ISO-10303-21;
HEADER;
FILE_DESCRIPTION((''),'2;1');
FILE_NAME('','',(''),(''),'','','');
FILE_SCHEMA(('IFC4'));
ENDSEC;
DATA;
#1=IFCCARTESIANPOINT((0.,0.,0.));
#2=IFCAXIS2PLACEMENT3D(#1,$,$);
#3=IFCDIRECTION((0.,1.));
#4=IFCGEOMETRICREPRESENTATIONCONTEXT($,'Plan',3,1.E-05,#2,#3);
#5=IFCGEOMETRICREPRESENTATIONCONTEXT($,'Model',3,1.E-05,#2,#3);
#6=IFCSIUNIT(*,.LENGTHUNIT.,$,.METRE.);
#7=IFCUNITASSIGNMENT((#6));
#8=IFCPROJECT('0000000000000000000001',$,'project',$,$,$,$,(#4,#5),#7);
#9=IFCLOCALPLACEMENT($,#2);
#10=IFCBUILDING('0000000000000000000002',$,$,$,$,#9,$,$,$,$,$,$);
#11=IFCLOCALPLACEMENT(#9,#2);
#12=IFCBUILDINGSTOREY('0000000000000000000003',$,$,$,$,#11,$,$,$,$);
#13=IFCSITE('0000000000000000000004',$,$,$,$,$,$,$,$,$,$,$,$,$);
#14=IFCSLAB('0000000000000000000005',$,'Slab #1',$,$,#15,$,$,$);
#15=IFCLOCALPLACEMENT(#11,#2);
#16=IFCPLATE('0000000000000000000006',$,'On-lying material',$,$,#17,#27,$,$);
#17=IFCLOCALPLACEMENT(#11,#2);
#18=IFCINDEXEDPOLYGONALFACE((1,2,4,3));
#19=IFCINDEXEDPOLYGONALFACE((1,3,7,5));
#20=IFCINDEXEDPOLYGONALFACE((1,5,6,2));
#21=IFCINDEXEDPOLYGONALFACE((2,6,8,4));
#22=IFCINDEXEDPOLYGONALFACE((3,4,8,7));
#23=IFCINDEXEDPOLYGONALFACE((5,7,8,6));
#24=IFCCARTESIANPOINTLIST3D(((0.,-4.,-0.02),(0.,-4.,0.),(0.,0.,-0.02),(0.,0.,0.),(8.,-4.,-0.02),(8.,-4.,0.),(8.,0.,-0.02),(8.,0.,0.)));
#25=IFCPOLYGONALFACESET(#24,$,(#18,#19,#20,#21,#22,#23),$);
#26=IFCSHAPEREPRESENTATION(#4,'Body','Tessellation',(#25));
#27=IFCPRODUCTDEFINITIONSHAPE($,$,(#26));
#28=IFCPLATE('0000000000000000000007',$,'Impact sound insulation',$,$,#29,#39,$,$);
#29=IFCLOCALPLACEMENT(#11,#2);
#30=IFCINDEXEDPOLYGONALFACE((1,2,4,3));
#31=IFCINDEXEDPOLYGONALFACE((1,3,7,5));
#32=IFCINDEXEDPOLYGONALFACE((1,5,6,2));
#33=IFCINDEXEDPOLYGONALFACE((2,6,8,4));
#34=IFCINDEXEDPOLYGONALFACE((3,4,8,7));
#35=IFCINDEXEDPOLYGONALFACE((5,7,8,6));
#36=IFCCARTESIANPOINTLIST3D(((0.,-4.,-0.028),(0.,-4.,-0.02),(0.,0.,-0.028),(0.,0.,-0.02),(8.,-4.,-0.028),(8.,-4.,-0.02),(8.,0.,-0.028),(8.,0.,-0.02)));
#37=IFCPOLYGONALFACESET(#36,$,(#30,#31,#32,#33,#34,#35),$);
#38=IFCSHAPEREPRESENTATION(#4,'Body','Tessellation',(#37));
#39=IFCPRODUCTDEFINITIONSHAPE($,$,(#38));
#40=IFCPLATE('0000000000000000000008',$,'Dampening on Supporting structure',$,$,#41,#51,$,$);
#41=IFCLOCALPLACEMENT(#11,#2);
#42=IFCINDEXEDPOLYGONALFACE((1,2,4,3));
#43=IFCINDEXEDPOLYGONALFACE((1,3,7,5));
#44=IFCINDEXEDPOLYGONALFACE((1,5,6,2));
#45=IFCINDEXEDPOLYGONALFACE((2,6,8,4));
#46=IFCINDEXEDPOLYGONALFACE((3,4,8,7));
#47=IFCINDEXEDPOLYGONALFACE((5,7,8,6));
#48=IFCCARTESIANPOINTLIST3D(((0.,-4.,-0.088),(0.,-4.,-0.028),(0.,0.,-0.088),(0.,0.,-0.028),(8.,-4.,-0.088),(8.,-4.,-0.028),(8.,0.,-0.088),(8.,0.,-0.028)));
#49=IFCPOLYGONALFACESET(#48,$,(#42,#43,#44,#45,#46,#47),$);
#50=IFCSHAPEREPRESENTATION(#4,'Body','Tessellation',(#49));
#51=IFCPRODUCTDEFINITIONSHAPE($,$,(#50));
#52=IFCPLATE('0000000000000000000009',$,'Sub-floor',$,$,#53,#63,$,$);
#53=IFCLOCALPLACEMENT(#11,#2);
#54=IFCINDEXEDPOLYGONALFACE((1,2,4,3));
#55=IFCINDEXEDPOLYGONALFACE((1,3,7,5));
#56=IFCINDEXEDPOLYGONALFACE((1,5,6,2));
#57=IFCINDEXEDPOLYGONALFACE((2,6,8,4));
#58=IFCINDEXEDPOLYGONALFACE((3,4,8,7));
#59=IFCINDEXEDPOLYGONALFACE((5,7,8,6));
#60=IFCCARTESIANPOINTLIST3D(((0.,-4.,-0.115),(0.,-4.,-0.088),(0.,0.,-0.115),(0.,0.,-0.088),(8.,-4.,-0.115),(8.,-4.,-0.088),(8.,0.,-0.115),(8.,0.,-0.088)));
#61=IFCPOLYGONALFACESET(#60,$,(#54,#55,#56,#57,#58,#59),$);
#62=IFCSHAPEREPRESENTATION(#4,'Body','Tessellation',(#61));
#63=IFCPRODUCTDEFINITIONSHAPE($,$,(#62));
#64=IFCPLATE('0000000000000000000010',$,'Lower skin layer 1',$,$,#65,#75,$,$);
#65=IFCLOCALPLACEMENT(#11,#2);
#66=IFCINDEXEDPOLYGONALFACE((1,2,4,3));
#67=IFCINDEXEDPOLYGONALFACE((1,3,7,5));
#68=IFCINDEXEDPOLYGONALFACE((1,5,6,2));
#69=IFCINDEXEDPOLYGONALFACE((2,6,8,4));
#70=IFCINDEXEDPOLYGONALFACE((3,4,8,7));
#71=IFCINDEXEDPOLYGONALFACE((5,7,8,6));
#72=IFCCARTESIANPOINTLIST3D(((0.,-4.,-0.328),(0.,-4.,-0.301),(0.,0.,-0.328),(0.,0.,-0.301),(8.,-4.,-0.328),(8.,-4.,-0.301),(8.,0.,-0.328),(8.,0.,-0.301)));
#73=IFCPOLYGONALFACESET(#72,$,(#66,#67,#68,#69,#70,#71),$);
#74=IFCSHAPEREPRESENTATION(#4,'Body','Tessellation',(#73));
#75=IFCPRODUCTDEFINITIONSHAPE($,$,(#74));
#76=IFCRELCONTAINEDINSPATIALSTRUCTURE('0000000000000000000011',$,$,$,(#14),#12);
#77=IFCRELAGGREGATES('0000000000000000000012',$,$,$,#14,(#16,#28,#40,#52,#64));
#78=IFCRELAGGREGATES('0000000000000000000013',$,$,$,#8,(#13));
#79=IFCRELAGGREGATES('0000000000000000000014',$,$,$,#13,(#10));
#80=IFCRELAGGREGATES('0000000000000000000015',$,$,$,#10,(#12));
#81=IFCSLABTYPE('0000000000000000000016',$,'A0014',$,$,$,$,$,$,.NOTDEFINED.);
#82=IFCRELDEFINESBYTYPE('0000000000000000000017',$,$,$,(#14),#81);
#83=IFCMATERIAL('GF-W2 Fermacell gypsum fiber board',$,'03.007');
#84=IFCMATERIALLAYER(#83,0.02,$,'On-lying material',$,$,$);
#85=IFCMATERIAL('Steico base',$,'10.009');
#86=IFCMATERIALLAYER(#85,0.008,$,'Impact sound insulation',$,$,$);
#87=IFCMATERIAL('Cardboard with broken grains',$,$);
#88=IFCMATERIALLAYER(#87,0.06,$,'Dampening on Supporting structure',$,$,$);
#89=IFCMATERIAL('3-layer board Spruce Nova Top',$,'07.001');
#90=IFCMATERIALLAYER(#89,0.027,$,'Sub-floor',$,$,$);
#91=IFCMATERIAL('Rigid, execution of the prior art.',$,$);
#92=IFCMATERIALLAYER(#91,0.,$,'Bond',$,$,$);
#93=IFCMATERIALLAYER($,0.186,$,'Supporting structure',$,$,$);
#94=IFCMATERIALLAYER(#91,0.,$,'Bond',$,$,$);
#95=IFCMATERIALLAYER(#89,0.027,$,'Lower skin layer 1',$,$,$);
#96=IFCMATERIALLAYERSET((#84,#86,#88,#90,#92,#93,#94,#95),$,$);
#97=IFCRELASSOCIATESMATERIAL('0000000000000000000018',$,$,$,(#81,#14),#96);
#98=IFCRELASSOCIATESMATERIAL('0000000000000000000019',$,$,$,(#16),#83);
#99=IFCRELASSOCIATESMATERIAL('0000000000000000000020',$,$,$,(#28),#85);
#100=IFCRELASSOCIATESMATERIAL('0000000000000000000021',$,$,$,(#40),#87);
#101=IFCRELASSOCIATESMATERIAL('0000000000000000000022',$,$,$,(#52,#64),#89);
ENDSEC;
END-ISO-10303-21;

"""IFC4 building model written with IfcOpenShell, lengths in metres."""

from ifc_helpers import new_model, si_unit, direction, frame, frame_2d, origin, origin_with_axes, place, context, project, spatial, rectangle, extrude, material, layer, layer_set, type_object, element, aggregate, save


model = new_model("IFC4")

# Units and contexts
plan_context = context("Plan", 3, precision=1e-05, world=origin(), true_north=direction((0.0, 1.0)))
model_context = context("Model", 3, precision=1e-05, world=origin(), true_north=direction((0.0, 1.0)))
ifc_project = project(units=[si_unit("LENGTHUNIT", "METRE")], contexts=[plan_context, model_context])

# Site, building, storey
site = spatial("IfcSite", under=ifc_project)
building_placement = place(None, origin())
building = spatial("IfcBuilding", under=site, at=building_placement)
storey_placement = place(building_placement, origin())
storey = spatial("IfcBuildingStorey", under=building, at=storey_placement)

# Slab, plates
ifc_material_1 = material(Name="GF-W2 Fermacell gypsum fiber board", Category="03.007")
ifc_layer_1 = layer(ifc_material_1, 0.02, Name="On-lying material")
ifc_material_2 = material(Name="Steico base", Category="10.009")
ifc_layer_2 = layer(ifc_material_2, 0.008, Name="Impact sound insulation")
ifc_material_3 = material(Name="Cardboard with broken grains")
ifc_layer_3 = layer(ifc_material_3, 0.06, Name="Dampening on Supporting structure")
ifc_material_4 = material(Name="3-layer board Spruce Nova Top", Category="07.001")
ifc_layer_4 = layer(ifc_material_4, 0.027, Name="Sub-floor")
ifc_material_5 = material(Name="Rigid, execution of the prior art.")
ifc_layer_5 = layer(ifc_material_5, 0.0, Name="Bond")
ifc_layer_6 = layer(None, 0.186, Name="Supporting structure")
ifc_layer_7 = layer(ifc_material_5, 0.0, Name="Bond")
ifc_layer_8 = layer(ifc_material_4, 0.027, Name="Lower skin layer 1")
ifc_layer_set = layer_set([ifc_layer_1, ifc_layer_2, ifc_layer_3, ifc_layer_4, ifc_layer_5, ifc_layer_6, ifc_layer_7, ifc_layer_8])
slab_type = type_object("IfcSlabType", Name="A0014", PredefinedType="NOTDEFINED", material=ifc_layer_set)
slab_placement = place(None, frame((0.0, 0.0, 0.0), z_axis=(0.0, 0.0, -1.0), x_axis=(1.0, 0.0, 0.0)))
slab = element("IfcSlab", 1, at=slab_placement, inside=storey, type_object=slab_type, material=ifc_layer_set, Name="Slab #1")
plate_1_placement = place(slab_placement, origin())
plate_1 = element("IfcPlate", 2, at=plate_1_placement, material=ifc_material_1, Name="On-lying material", context=plan_context, shape_type="SweptSolid", body=[
    extrude(rectangle(XDim=8.0, YDim=4.0, at=frame_2d((4.0, 2.0), x_axis=(1.0, 0.0))), origin_with_axes(), (0.0, 0.0, 1.0), 0.02),
])
plate_2_placement = place(slab_placement, origin())
plate_2 = element("IfcPlate", 3, at=plate_2_placement, material=ifc_material_2, Name="Impact sound insulation", context=plan_context, shape_type="SweptSolid", body=[
    extrude(rectangle(XDim=8.0, YDim=4.0, at=frame_2d((4.0, 2.0), x_axis=(1.0, 0.0))), frame((0.0, 0.0, 0.02), z_axis=(0.0, 0.0, 1.0), x_axis=(1.0, 0.0, 0.0)), (0.0, 0.0, 1.0), 0.008),
])
plate_3_placement = place(slab_placement, origin())
plate_3 = element("IfcPlate", 4, at=plate_3_placement, material=ifc_material_3, Name="Dampening on Supporting structure", context=plan_context, shape_type="SweptSolid", body=[
    extrude(rectangle(XDim=8.0, YDim=4.0, at=frame_2d((4.0, 2.0), x_axis=(1.0, 0.0))), frame((0.0, 0.0, 0.028), z_axis=(0.0, 0.0, 1.0), x_axis=(1.0, 0.0, 0.0)), (0.0, 0.0, 1.0), 0.06),
])
plate_4_placement = place(slab_placement, origin())
plate_4 = element("IfcPlate", 5, at=plate_4_placement, material=ifc_material_4, Name="Sub-floor", context=plan_context, shape_type="SweptSolid", body=[
    extrude(rectangle(XDim=8.0, YDim=4.0, at=frame_2d((4.0, 2.0), x_axis=(1.0, 0.0))), frame((0.0, 0.0, 0.088), z_axis=(0.0, 0.0, 1.0), x_axis=(1.0, 0.0, 0.0)), (0.0, 0.0, 1.0), 0.027),
])
plate_5_placement = place(slab_placement, origin())
plate_5 = element("IfcPlate", 6, at=plate_5_placement, material=ifc_material_4, Name="Lower skin layer 1", context=plan_context, shape_type="SweptSolid", body=[
    extrude(rectangle(XDim=8.0, YDim=4.0, at=frame_2d((4.0, 2.0), x_axis=(1.0, 0.0))), frame((0.0, 0.0, 0.301), z_axis=(0.0, 0.0, 1.0), x_axis=(1.0, 0.0, 0.0)), (0.0, 0.0, 1.0), 0.027),
])
aggregate(slab, [plate_1, plate_2, plate_3, plate_4, plate_5])

save(model, "model.ifc")
